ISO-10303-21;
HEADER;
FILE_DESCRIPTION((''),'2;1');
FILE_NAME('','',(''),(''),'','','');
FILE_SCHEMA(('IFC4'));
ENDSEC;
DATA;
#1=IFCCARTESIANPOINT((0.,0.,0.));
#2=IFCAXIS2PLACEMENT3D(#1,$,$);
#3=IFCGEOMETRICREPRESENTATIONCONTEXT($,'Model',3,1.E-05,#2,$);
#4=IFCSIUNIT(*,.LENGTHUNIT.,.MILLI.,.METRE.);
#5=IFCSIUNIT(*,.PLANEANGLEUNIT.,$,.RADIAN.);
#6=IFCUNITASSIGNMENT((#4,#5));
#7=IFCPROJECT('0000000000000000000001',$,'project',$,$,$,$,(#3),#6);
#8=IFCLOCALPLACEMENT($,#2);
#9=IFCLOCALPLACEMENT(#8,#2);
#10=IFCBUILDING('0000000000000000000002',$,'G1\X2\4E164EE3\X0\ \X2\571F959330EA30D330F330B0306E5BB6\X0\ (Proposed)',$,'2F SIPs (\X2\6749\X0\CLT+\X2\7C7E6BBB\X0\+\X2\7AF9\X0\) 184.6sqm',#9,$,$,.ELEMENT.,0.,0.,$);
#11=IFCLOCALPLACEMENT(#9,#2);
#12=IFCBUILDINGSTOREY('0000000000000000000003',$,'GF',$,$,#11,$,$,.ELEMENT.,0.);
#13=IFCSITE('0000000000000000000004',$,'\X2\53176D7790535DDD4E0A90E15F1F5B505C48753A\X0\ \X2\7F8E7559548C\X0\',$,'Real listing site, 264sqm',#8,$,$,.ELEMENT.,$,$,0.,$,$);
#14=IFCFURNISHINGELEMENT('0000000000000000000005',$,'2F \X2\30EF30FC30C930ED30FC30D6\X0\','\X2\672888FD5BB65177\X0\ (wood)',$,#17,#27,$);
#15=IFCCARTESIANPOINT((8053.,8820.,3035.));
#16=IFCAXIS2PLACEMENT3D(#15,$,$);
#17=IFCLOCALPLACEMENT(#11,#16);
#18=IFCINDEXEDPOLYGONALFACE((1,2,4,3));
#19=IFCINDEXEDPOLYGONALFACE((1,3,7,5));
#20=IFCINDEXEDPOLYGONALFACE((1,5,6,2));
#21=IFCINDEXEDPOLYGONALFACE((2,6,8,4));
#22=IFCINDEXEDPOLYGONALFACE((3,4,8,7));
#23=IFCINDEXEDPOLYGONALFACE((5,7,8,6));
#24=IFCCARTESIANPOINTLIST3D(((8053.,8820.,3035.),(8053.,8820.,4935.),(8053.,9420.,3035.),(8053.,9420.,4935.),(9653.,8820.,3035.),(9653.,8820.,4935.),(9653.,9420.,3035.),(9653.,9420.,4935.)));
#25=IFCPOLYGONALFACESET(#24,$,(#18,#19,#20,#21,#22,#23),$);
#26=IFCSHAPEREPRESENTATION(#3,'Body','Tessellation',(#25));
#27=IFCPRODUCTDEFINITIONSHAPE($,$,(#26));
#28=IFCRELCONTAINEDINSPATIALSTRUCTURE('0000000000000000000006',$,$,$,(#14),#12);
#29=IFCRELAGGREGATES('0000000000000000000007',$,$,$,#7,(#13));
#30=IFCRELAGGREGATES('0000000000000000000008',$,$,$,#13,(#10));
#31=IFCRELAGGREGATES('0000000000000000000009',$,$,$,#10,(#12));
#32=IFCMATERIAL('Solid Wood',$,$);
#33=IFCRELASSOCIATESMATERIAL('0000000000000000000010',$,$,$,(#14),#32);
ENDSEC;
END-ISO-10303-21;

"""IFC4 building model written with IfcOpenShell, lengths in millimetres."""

from ifc_helpers import new_model, si_unit, frame, frame_2d, origin, place, context, project, spatial, rectangle, extrude, material, element, save


model = new_model("IFC4")

# Units and contexts
model_context = context("Model", 3, precision=1e-05, world=origin())
ifc_project = project(units=[si_unit("LENGTHUNIT", "METRE", prefix="MILLI"), si_unit("PLANEANGLEUNIT", "RADIAN")], contexts=[model_context])

# Site, building, storey
site_placement = place(None, origin())
site = spatial("IfcSite", under=ifc_project, at=site_placement, Name="北海道川上郡弟子屈町 美留和", ObjectType="Real listing site, 264sqm", CompositionType="ELEMENT", RefElevation=0.0)
building_placement = place(site_placement, origin())
building = spatial("IfcBuilding", under=site, at=building_placement, Name="G1世代 土間リビングの家 (Proposed)", ObjectType="2F SIPs (杉CLT+籾殻+竹) 184.6sqm", CompositionType="ELEMENT", ElevationOfRefHeight=0.0, ElevationOfTerrain=0.0)
storey_placement = place(building_placement, origin())
storey = spatial("IfcBuildingStorey", under=building, at=storey_placement, Name="GF", CompositionType="ELEMENT", Elevation=0.0)

# Shared definitions
ifc_material_1 = material(Name="Solid Wood")

# Furnishing element
furnishing_1_placement = place(storey_placement, frame((8053.0, 8820.0, 3035.0)))
element("IfcFurnishingElement", 1, at=furnishing_1_placement, inside=storey, material=ifc_material_1, Name="2F ワードローブ", Description="木製家具 (wood)", context=model_context, shape_type="SweptSolid", body=[
    extrude(rectangle(XDim=1600.0, YDim=600.0, at=frame_2d((800.0, 300.0))), frame((8053.0, 8820.0, 3035.0)), (0.0, 0.0, 1.0), 1900.0),
])

save(model, "model.ifc")
